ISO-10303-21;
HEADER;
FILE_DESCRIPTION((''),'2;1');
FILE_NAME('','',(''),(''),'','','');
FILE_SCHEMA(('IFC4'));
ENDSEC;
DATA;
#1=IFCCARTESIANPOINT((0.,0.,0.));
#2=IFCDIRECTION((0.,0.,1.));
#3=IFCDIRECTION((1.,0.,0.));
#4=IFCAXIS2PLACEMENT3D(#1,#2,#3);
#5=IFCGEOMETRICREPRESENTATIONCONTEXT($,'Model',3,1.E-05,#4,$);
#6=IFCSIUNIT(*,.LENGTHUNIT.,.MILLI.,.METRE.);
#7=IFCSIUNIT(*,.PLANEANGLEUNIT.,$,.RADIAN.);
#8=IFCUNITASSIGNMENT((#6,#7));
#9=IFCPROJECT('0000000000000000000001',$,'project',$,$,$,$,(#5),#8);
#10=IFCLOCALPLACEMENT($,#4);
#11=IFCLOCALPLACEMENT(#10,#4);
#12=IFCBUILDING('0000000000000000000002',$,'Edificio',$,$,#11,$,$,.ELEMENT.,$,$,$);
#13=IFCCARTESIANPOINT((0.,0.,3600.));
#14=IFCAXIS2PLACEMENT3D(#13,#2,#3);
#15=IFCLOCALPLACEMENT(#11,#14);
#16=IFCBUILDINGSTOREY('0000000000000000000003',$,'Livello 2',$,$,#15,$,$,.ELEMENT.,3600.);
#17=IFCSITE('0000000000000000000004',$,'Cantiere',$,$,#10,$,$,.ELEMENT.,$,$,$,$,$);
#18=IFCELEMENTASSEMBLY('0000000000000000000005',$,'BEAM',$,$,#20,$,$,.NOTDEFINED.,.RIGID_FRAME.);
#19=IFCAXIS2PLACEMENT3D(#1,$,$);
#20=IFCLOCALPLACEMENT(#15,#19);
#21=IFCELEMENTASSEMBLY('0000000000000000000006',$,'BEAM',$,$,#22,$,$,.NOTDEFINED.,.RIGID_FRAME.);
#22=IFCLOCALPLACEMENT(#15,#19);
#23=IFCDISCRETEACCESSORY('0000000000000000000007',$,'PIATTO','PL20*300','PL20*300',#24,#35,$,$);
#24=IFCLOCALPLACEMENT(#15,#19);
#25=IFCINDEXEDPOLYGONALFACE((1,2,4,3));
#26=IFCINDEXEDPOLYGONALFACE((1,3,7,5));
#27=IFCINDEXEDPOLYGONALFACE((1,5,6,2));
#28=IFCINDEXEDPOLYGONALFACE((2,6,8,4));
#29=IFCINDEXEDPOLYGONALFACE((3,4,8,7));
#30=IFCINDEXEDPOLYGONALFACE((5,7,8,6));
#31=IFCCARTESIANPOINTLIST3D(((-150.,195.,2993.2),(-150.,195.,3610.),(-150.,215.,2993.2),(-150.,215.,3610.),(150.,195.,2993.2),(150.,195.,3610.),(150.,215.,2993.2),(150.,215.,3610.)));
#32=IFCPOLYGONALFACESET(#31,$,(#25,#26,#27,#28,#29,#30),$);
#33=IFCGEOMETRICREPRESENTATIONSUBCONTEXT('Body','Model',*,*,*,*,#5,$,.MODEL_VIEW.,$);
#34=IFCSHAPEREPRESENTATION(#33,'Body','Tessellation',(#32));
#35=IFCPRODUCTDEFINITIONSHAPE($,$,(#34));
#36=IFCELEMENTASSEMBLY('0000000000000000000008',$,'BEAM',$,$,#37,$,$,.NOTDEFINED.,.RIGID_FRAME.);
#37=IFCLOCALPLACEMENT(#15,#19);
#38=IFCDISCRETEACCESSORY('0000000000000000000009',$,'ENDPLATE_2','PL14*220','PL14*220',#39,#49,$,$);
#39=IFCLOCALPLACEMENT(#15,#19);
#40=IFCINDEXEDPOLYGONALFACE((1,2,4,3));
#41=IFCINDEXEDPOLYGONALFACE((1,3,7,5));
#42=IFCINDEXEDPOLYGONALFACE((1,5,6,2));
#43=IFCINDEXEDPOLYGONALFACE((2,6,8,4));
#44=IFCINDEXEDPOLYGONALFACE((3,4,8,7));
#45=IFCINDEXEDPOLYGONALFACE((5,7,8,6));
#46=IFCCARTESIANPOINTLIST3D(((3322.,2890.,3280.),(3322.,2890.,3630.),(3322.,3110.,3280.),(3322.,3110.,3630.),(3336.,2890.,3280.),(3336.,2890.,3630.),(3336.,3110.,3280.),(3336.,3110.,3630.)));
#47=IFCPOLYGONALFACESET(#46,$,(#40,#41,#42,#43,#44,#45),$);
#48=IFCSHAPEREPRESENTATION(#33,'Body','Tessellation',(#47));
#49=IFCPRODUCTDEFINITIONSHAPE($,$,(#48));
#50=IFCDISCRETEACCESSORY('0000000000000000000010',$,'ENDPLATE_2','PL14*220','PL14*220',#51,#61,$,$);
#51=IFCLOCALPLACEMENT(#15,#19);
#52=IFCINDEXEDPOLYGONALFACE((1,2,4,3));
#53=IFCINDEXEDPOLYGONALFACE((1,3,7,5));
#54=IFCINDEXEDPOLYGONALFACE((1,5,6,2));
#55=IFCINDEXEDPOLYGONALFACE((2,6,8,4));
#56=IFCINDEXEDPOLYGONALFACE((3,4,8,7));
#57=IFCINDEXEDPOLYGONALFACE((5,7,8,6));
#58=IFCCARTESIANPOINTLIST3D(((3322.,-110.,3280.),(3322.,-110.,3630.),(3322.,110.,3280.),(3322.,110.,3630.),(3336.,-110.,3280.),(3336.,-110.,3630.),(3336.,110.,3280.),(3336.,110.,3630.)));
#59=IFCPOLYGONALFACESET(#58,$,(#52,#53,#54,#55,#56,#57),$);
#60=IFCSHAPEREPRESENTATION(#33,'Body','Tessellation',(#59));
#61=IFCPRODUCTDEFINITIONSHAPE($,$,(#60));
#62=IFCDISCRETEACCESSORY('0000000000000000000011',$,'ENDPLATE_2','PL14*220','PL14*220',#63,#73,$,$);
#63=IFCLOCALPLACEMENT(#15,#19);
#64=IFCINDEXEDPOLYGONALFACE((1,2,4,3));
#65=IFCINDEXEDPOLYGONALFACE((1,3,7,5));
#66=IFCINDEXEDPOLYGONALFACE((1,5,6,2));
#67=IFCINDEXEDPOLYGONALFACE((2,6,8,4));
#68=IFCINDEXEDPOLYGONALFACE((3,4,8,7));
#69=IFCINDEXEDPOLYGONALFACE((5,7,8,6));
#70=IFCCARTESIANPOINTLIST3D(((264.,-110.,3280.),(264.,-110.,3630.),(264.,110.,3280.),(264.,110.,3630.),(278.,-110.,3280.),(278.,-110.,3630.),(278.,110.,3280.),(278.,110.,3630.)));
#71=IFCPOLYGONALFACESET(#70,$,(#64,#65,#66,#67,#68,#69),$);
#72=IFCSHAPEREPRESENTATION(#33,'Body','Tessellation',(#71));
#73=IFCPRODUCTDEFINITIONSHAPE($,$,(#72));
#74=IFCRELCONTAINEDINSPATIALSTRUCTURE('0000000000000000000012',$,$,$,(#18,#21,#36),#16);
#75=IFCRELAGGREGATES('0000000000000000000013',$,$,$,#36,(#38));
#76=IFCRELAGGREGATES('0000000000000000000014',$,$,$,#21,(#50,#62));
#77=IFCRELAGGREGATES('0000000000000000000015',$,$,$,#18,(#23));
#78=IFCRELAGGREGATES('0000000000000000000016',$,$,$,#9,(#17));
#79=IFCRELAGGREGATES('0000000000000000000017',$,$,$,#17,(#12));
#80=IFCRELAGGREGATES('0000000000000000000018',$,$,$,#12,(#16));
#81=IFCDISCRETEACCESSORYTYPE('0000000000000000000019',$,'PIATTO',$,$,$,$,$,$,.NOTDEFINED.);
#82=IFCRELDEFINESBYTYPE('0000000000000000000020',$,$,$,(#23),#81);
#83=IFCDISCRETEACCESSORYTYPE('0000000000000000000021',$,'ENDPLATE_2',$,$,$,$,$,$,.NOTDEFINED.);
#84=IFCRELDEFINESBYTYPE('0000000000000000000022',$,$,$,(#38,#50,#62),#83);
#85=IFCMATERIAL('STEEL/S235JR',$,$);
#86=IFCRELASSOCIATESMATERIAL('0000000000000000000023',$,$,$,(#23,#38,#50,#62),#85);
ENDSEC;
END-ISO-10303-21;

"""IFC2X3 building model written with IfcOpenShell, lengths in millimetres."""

from ifc_helpers import new_model, si_unit, frame, origin_with_axes, place, context, subcontext, project, spatial, polyline, outline, extrude, material, type_object, element, aggregate, save


model = new_model("IFC2X3")

# Units and contexts
model_context = context("Model", 3, precision=1e-05, world=origin_with_axes())
body_context = subcontext(model_context, "Body", "Model", "MODEL_VIEW")
ifc_project = project(units=[si_unit("LENGTHUNIT", "METRE", prefix="MILLI"), si_unit("PLANEANGLEUNIT", "RADIAN")], contexts=[model_context])

# Site, building, storey
site_placement = place(None, origin_with_axes())
site = spatial("IfcSite", under=ifc_project, at=site_placement, Name="Cantiere", CompositionType="ELEMENT")
building_placement = place(site_placement, origin_with_axes())
building = spatial("IfcBuilding", under=site, at=building_placement, Name="Edificio", CompositionType="ELEMENT")
storey_placement = place(building_placement, frame((0.0, 0.0, 3600.0), z_axis=(0.0, 0.0, 1.0), x_axis=(1.0, 0.0, 0.0)))
storey = spatial("IfcBuildingStorey", under=building, at=storey_placement, Name="Livello 2", CompositionType="ELEMENT", Elevation=3600.0)

# Element assemblies
assembly_1_placement = place(storey_placement, origin_with_axes())
assembly_1 = element("IfcElementAssembly", 1, at=assembly_1_placement, inside=storey, Name="BEAM", AssemblyPlace="NOTDEFINED", PredefinedType="RIGID_FRAME")
ifc_material_1 = material(Name="STEEL/S235JR")
assembly_2_placement = place(storey_placement, origin_with_axes())
assembly_2 = element("IfcElementAssembly", 2, at=assembly_2_placement, inside=storey, Name="BEAM", AssemblyPlace="NOTDEFINED", PredefinedType="RIGID_FRAME")

# Discrete accessory
discrete_accessory_type_1 = type_object("IfcDiscreteAccessoryType", Name="PIATTO")
discrete_accessory_1_placement = place(assembly_1_placement, frame((0.0, 205.0, 2993.2), z_axis=(0.0, 1.0, 0.0), x_axis=(0.0, 0.0, 1.0)))
discrete_accessory_1 = element("IfcDiscreteAccessory", 3, at=discrete_accessory_1_placement, type_object=discrete_accessory_type_1, material=ifc_material_1, Name="PIATTO", Description="PL20*300", ObjectType="PL20*300", context=body_context, shape_type="SweptSolid", body=[
    extrude(outline(polyline([(0.0, -150.0), (0.0, 150.0), (616.8, 150.0), (616.8, -150.0), (0.0, -150.0)])), frame((0.0, 0.0, -10.0), z_axis=(0.0, 0.0, 1.0), x_axis=(1.0, 0.0, 0.0)), (0.0, 0.0, 1.0), 20.0),
])

# Element assembly
assembly_3_placement = place(storey_placement, origin_with_axes())
assembly_3 = element("IfcElementAssembly", 4, at=assembly_3_placement, inside=storey, Name="BEAM", AssemblyPlace="NOTDEFINED", PredefinedType="RIGID_FRAME")

# Discrete accessories
discrete_accessory_type_2 = type_object("IfcDiscreteAccessoryType", Name="ENDPLATE_2")
discrete_accessory_2_placement = place(assembly_3_placement, frame((3329.0, 2890.0, 3280.0), z_axis=(-1.0, 0.0, 0.0), x_axis=(0.0, 0.0, 1.0)))
discrete_accessory_2 = element("IfcDiscreteAccessory", 5, at=discrete_accessory_2_placement, type_object=discrete_accessory_type_2, material=ifc_material_1, Name="ENDPLATE_2", Description="PL14*220", ObjectType="PL14*220", context=body_context, shape_type="SweptSolid", body=[
    extrude(outline(polyline([(0.0, 0.0), (350.0, 0.0), (350.0, 220.0), (0.0, 220.0), (0.0, 0.0)])), frame((0.0, 0.0, -7.0), z_axis=(0.0, 0.0, 1.0), x_axis=(1.0, 0.0, 0.0)), (0.0, 0.0, 1.0), 14.0),
])
aggregate(assembly_3, [discrete_accessory_2])
discrete_accessory_3_placement = place(assembly_2_placement, frame((3329.0, -110.0, 3280.0), z_axis=(-1.0, 0.0, 0.0), x_axis=(0.0, 0.0, 1.0)))
discrete_accessory_3 = element("IfcDiscreteAccessory", 6, at=discrete_accessory_3_placement, type_object=discrete_accessory_type_2, material=ifc_material_1, Name="ENDPLATE_2", Description="PL14*220", ObjectType="PL14*220", context=body_context, shape_type="SweptSolid", body=[
    extrude(outline(polyline([(0.0, 0.0), (350.0, 0.0), (350.0, 220.0), (0.0, 220.0), (0.0, 0.0)])), frame((0.0, 0.0, -7.0), z_axis=(0.0, 0.0, 1.0), x_axis=(1.0, 0.0, 0.0)), (0.0, 0.0, 1.0), 14.0),
])
discrete_accessory_4_placement = place(assembly_2_placement, frame((271.0, 110.0, 3280.0), z_axis=(1.0, 0.0, 0.0), x_axis=(0.0, 0.0, 1.0)))
discrete_accessory_4 = element("IfcDiscreteAccessory", 7, at=discrete_accessory_4_placement, type_object=discrete_accessory_type_2, material=ifc_material_1, Name="ENDPLATE_2", Description="PL14*220", ObjectType="PL14*220", context=body_context, shape_type="SweptSolid", body=[
    extrude(outline(polyline([(0.0, 0.0), (350.0, 0.0), (350.0, 220.0), (0.0, 220.0), (0.0, 0.0)])), frame((0.0, 0.0, -7.0), z_axis=(0.0, 0.0, 1.0), x_axis=(1.0, 0.0, 0.0)), (0.0, 0.0, 1.0), 14.0),
])
aggregate(assembly_2, [discrete_accessory_3, discrete_accessory_4])

aggregate(assembly_1, [discrete_accessory_1])

save(model, "model.ifc")
